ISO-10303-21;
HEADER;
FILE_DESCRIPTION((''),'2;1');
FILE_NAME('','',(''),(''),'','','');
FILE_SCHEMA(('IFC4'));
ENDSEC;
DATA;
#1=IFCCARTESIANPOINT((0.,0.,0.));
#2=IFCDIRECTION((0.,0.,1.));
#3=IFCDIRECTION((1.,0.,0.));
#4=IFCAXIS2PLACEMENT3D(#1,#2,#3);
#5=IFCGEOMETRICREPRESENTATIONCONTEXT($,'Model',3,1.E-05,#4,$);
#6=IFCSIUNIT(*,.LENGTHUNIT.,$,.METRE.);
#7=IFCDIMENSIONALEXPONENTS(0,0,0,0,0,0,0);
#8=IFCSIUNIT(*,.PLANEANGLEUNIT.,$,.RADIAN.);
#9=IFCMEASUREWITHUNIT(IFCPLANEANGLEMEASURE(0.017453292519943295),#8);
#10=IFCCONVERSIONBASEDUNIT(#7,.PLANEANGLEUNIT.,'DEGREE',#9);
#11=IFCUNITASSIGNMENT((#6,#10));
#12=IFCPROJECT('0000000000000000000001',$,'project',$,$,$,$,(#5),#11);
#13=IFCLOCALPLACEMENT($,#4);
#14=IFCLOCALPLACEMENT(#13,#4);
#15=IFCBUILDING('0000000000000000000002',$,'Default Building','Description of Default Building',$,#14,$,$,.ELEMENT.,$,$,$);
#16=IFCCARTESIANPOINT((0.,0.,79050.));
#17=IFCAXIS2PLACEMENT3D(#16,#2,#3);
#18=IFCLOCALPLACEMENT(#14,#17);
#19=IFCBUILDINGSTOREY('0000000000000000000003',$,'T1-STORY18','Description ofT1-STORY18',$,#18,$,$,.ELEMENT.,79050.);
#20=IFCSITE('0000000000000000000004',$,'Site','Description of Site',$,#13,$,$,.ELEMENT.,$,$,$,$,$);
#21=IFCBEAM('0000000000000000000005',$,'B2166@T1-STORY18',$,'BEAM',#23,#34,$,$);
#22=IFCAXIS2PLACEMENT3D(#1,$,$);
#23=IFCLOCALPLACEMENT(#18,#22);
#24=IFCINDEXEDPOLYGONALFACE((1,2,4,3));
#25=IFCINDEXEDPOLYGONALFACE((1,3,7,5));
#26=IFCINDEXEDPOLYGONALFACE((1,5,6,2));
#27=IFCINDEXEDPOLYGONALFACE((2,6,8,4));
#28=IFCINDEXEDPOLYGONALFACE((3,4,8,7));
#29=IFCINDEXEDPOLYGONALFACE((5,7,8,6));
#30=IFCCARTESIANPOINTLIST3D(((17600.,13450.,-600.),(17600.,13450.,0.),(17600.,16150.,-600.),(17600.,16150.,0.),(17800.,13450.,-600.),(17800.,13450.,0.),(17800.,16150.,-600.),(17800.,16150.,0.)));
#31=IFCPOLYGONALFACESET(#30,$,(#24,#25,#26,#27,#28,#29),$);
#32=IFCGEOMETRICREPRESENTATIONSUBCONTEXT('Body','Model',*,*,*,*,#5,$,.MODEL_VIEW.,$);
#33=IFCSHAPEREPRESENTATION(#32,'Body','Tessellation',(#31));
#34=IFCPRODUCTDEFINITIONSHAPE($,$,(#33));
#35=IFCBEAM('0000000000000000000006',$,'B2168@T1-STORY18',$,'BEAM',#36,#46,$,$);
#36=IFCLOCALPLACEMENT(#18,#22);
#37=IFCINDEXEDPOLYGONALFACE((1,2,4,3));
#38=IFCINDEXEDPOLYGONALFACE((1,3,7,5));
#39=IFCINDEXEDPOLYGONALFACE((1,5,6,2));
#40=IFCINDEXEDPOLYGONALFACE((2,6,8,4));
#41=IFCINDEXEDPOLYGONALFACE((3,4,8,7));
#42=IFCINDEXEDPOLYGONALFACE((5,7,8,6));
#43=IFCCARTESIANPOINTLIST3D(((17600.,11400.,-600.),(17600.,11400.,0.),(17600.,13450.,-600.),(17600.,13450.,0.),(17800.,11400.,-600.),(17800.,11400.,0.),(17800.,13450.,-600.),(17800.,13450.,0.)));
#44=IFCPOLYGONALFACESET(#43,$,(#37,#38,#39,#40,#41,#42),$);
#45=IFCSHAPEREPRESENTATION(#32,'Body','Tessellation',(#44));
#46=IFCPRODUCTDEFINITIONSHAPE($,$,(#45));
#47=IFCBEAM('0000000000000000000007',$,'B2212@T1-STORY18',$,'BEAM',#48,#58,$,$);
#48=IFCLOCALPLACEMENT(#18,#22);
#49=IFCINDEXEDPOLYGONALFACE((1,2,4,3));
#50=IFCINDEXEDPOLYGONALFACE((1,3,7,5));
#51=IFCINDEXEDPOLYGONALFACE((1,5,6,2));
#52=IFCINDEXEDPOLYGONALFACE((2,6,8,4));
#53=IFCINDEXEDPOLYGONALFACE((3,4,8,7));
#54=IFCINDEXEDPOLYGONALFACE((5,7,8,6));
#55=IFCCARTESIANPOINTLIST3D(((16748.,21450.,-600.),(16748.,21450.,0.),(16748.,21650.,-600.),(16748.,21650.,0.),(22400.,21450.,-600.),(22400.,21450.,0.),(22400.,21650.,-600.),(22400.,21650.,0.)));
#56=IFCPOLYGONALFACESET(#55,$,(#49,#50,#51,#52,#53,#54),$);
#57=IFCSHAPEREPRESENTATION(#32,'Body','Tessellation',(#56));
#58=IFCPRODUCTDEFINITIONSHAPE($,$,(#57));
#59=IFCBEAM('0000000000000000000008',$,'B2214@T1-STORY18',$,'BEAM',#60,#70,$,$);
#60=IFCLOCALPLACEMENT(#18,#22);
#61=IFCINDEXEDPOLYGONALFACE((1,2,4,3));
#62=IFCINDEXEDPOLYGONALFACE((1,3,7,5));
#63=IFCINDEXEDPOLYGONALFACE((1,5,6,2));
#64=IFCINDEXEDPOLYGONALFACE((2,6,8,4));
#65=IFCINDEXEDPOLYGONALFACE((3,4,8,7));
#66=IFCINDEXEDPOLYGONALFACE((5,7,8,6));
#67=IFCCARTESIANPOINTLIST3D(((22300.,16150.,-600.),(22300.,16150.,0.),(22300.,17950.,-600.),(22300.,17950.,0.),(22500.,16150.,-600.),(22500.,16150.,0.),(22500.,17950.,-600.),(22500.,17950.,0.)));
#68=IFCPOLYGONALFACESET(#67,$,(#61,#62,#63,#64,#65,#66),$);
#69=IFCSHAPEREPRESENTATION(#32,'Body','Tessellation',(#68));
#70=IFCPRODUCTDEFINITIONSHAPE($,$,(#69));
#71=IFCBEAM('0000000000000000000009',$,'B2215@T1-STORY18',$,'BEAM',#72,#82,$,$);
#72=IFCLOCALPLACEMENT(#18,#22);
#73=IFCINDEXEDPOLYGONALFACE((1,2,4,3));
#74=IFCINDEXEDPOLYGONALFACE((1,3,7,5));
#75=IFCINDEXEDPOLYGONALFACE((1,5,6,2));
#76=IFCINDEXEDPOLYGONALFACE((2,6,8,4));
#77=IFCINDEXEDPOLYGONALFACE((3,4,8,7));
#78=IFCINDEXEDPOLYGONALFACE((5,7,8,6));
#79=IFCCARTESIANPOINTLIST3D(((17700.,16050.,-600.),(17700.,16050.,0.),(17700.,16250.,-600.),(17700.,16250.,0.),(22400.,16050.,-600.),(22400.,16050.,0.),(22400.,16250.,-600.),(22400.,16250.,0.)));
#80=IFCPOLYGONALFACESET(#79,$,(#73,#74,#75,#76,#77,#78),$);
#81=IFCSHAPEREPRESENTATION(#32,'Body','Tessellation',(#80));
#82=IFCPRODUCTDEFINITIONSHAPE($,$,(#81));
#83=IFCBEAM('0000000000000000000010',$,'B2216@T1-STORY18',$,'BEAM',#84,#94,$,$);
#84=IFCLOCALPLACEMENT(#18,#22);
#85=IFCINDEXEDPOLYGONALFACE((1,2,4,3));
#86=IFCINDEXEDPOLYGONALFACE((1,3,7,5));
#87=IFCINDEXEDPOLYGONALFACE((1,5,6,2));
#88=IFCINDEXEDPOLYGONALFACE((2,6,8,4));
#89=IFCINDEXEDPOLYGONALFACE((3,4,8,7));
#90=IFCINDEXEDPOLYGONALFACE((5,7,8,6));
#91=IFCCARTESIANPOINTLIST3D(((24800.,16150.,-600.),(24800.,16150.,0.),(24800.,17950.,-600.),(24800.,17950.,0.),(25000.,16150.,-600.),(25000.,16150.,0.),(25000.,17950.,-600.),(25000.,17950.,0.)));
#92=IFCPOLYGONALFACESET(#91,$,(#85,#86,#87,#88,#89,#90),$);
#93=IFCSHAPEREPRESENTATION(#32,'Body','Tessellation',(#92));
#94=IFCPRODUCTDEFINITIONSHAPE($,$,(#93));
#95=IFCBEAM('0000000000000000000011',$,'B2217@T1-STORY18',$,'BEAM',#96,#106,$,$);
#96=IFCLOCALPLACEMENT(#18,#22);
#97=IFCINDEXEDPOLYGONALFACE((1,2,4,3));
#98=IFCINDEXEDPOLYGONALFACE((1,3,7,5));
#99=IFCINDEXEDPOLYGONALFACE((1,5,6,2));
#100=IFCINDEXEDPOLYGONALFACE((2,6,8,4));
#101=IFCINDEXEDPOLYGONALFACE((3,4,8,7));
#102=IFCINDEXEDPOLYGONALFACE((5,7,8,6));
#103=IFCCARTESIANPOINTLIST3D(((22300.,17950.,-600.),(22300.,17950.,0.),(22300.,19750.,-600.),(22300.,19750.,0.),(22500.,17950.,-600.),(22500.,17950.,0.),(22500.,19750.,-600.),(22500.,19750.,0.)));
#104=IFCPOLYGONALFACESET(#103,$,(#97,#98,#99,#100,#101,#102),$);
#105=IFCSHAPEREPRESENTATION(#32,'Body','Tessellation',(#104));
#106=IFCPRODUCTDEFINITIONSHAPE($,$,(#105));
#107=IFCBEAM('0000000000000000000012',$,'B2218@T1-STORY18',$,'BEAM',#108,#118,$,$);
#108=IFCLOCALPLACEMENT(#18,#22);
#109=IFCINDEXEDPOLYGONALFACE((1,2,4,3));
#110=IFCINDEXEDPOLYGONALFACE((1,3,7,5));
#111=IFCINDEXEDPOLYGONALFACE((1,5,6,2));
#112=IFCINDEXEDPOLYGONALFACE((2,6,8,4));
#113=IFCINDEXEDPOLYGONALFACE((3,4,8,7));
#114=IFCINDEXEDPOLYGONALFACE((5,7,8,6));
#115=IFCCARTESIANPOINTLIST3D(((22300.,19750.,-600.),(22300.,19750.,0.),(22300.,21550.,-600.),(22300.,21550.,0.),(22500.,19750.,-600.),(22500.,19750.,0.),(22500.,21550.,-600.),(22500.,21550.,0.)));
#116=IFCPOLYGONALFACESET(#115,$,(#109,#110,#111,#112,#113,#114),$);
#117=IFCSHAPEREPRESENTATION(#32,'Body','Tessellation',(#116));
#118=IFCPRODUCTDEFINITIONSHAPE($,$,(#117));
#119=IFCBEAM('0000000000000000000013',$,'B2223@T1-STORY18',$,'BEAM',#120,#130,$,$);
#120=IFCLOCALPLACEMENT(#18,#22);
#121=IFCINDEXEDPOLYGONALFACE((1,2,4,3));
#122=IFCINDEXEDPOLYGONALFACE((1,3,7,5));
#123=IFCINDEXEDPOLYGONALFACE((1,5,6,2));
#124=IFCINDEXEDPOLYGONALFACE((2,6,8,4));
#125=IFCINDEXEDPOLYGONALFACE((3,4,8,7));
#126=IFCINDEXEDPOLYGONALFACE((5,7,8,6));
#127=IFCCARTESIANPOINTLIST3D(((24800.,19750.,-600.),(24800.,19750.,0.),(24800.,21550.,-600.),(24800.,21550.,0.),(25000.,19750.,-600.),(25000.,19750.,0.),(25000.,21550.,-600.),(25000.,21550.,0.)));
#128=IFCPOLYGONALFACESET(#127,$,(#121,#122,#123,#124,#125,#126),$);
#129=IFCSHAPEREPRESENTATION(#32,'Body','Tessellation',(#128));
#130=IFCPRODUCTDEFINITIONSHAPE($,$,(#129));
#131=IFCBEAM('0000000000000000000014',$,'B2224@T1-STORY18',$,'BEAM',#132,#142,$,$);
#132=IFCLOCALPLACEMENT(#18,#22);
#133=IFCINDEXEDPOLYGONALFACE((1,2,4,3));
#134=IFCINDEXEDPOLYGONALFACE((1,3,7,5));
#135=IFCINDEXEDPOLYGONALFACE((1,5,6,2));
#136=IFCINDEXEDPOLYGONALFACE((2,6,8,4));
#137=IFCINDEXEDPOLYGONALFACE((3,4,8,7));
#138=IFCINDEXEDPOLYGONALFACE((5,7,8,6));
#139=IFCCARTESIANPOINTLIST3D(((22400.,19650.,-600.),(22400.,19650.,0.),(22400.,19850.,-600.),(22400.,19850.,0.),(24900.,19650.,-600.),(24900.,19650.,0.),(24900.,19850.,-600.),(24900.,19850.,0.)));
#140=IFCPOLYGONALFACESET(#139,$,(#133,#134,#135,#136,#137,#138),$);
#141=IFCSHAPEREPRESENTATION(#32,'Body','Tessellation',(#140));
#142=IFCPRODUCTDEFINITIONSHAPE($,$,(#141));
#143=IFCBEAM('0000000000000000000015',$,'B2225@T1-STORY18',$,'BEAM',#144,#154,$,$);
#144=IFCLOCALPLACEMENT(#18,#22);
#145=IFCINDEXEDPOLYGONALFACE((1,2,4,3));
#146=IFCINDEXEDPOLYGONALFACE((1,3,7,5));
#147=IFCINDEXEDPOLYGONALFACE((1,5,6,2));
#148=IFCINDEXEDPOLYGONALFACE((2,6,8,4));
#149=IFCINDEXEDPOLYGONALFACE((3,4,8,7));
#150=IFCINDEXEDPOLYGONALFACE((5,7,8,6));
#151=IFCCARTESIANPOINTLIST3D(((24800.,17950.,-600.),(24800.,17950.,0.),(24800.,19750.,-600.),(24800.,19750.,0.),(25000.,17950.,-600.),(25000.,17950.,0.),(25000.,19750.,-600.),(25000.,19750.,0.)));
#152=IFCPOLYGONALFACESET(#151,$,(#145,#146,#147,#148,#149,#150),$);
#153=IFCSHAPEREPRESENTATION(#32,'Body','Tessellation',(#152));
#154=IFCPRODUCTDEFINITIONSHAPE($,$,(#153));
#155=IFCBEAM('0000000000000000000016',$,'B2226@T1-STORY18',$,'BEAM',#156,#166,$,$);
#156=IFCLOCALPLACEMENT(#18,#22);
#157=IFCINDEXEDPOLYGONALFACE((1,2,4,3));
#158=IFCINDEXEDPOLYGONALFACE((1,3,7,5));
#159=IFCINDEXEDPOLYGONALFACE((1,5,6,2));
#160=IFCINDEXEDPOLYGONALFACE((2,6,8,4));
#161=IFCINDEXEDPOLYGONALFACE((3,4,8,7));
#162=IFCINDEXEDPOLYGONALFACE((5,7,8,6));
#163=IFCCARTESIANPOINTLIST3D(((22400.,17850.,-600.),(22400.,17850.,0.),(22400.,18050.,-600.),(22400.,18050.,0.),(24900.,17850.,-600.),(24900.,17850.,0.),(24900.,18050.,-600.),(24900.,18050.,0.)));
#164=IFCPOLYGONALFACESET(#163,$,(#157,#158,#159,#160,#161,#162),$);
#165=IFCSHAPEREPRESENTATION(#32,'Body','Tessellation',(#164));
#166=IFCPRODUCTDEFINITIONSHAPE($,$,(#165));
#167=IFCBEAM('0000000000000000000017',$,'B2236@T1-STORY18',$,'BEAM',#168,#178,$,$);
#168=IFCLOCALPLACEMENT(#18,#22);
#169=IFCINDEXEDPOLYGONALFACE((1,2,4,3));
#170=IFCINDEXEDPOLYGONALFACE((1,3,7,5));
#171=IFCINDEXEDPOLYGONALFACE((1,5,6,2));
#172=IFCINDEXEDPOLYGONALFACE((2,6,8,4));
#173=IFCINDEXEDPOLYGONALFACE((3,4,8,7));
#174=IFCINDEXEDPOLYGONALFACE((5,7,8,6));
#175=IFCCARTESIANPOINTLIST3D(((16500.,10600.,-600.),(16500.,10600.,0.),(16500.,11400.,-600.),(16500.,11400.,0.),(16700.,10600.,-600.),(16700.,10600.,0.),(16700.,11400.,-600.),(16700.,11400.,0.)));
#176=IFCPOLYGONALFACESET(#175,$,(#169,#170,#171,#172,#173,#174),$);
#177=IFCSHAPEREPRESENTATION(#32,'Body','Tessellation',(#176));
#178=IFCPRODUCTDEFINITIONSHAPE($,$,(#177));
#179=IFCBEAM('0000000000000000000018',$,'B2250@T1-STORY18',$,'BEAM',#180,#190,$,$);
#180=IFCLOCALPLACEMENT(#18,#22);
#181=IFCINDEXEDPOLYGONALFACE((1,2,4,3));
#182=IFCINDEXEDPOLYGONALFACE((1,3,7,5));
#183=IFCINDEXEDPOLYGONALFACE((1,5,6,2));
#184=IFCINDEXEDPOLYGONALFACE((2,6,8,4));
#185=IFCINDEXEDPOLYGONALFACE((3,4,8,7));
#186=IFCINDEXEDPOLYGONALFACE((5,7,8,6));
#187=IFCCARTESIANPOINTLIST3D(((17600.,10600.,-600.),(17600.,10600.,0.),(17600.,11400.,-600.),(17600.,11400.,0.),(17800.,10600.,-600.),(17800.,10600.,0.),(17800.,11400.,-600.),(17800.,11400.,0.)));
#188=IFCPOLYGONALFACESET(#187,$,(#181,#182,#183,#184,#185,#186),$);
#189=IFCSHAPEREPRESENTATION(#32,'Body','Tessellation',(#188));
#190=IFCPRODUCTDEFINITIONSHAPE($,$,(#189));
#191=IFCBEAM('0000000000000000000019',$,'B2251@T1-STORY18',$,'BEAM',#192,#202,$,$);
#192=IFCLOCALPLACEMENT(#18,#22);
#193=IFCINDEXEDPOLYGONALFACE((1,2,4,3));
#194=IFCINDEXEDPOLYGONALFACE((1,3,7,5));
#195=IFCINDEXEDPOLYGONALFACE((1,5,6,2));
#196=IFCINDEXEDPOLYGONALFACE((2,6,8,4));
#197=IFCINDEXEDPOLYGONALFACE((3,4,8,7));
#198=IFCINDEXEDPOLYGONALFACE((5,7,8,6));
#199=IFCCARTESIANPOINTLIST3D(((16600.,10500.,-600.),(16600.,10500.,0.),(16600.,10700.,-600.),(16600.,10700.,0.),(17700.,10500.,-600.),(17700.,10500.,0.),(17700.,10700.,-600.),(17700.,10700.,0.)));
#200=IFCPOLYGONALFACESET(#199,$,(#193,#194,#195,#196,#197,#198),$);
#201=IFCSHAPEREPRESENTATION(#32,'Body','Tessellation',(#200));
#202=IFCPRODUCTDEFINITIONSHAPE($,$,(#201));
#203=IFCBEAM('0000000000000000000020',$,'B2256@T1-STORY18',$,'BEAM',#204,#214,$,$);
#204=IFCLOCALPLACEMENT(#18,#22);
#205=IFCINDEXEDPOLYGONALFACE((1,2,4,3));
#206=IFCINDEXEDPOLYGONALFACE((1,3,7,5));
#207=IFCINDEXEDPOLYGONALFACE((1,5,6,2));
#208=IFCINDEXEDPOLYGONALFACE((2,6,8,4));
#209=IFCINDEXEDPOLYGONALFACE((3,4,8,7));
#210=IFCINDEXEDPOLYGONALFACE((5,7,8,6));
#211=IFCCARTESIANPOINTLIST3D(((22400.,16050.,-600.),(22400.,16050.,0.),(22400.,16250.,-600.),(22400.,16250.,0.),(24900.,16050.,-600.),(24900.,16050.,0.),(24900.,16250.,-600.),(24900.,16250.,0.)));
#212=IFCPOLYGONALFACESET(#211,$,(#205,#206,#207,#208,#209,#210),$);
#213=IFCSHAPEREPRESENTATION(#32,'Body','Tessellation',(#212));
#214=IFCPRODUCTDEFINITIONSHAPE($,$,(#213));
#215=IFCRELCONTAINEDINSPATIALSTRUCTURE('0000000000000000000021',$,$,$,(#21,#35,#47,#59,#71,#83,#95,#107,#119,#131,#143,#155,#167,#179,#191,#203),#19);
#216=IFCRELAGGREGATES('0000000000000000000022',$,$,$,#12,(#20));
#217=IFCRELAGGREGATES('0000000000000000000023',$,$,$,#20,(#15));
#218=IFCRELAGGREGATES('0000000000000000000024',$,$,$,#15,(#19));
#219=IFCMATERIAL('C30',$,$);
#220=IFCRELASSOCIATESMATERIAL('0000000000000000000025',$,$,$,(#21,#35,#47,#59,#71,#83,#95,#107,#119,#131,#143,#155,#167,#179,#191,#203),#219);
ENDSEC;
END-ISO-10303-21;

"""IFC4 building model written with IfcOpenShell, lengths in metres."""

from ifc_helpers import new_model, entity, si_unit, converted_unit, frame, origin_with_axes, place, context, subcontext, project, spatial, rectangle, extrude, material, element, save


model = new_model("IFC4")

# Units and contexts
model_context = context("Model", 3, precision=1e-05, world=origin_with_axes())
body_context = subcontext(model_context, "Body", "Model", "MODEL_VIEW")
ifc_project = project(units=[si_unit("LENGTHUNIT", "METRE"), converted_unit("PLANEANGLEUNIT", "DEGREE", entity("IfcPlaneAngleMeasure", 0.017453292519943295), si_unit("PLANEANGLEUNIT", "RADIAN"), dimensions=[0, 0, 0, 0, 0, 0, 0])], contexts=[model_context])

# Site, building, storey
site_placement = place(None, origin_with_axes())
site = spatial("IfcSite", under=ifc_project, at=site_placement, Name="Site", Description="Description of Site", CompositionType="ELEMENT")
building_placement = place(site_placement, origin_with_axes())
building = spatial("IfcBuilding", under=site, at=building_placement, Name="Default Building", Description="Description of Default Building", CompositionType="ELEMENT")
storey_placement = place(building_placement, frame((0.0, 0.0, 79050.0), z_axis=(0.0, 0.0, 1.0), x_axis=(1.0, 0.0, 0.0)))
storey = spatial("IfcBuildingStorey", under=building, at=storey_placement, Name="T1-STORY18", Description="Description ofT1-STORY18", CompositionType="ELEMENT", Elevation=79050.0)

# Beams
ifc_material_1 = material(Name="C30")
beam_1_placement = place(storey_placement, frame((17700.0, 13450.0, -300.0), z_axis=(0.0, 1.0, 0.0), x_axis=(-1.0, 0.0, 0.0)))
element("IfcBeam", 1, at=beam_1_placement, inside=storey, material=ifc_material_1, Name="B2166@T1-STORY18", ObjectType="BEAM", context=body_context, shape_type="SweptSolid", body=[
    extrude(rectangle(XDim=200.0, YDim=600.0), origin_with_axes(), (0.0, 0.0, 1.0), 2700.0),
])
beam_2_placement = place(storey_placement, frame((17700.0, 11400.0, -300.0), z_axis=(0.0, 1.0, 0.0), x_axis=(-1.0, 0.0, 0.0)))
element("IfcBeam", 2, at=beam_2_placement, inside=storey, material=ifc_material_1, Name="B2168@T1-STORY18", ObjectType="BEAM", context=body_context, shape_type="SweptSolid", body=[
    extrude(rectangle(XDim=200.0, YDim=600.0), origin_with_axes(), (0.0, 0.0, 1.0), 2050.0),
])
beam_3_placement = place(storey_placement, frame((16748.0, 21550.0, -300.0), z_axis=(1.0, 0.0, 0.0), x_axis=(0.0, 1.0, 0.0)))
element("IfcBeam", 3, at=beam_3_placement, inside=storey, material=ifc_material_1, Name="B2212@T1-STORY18", ObjectType="BEAM", context=body_context, shape_type="SweptSolid", body=[
    extrude(rectangle(XDim=200.0, YDim=600.0), origin_with_axes(), (0.0, 0.0, 1.0), 5652.0),
])
beam_4_placement = place(storey_placement, frame((22400.0, 16150.0, -300.0), z_axis=(0.0, 1.0, 0.0), x_axis=(-1.0, 0.0, 0.0)))
element("IfcBeam", 4, at=beam_4_placement, inside=storey, material=ifc_material_1, Name="B2214@T1-STORY18", ObjectType="BEAM", context=body_context, shape_type="SweptSolid", body=[
    extrude(rectangle(XDim=200.0, YDim=600.0), origin_with_axes(), (0.0, 0.0, 1.0), 1800.0),
])
beam_5_placement = place(storey_placement, frame((17700.0, 16150.0, -300.0), z_axis=(1.0, 0.0, 0.0), x_axis=(0.0, 1.0, 0.0)))
element("IfcBeam", 5, at=beam_5_placement, inside=storey, material=ifc_material_1, Name="B2215@T1-STORY18", ObjectType="BEAM", context=body_context, shape_type="SweptSolid", body=[
    extrude(rectangle(XDim=200.0, YDim=600.0), origin_with_axes(), (0.0, 0.0, 1.0), 4700.0),
])
for number, where, z_axis, x_axis, name in (
    (6, (24900.0, 16150.0, -300.0), (0.0, 1.0, 0.0), (-1.0, 0.0, 0.0), "B2216@T1-STORY18"),
    (7, (22400.0, 17950.0, -300.0), (0.0, 1.0, 0.0), (-1.0, 0.0, 0.0), "B2217@T1-STORY18"),
    (8, (22400.0, 19750.0, -300.0), (0.0, 1.0, 0.0), (-1.0, 0.0, 0.0), "B2218@T1-STORY18"),
    (9, (24900.0, 19750.0, -300.0), (0.0, 1.0, 0.0), (-1.0, 0.0, 0.0), "B2223@T1-STORY18"),
):
    element("IfcBeam", number, at=place(storey_placement, frame(where, z_axis=z_axis, x_axis=x_axis)), inside=storey, material=ifc_material_1, Name=name, ObjectType="BEAM", context=body_context, shape_type="SweptSolid", body=[
        extrude(rectangle(XDim=200.0, YDim=600.0), origin_with_axes(), (0.0, 0.0, 1.0), 1800.0),
    ])
beam_6_placement = place(storey_placement, frame((22400.0, 19750.0, -300.0), z_axis=(1.0, 0.0, 0.0), x_axis=(0.0, 1.0, 0.0)))
element("IfcBeam", 10, at=beam_6_placement, inside=storey, material=ifc_material_1, Name="B2224@T1-STORY18", ObjectType="BEAM", context=body_context, shape_type="SweptSolid", body=[
    extrude(rectangle(XDim=200.0, YDim=600.0), origin_with_axes(), (0.0, 0.0, 1.0), 2500.0),
])
beam_7_placement = place(storey_placement, frame((24900.0, 17950.0, -300.0), z_axis=(0.0, 1.0, 0.0), x_axis=(-1.0, 0.0, 0.0)))
element("IfcBeam", 11, at=beam_7_placement, inside=storey, material=ifc_material_1, Name="B2225@T1-STORY18", ObjectType="BEAM", context=body_context, shape_type="SweptSolid", body=[
    extrude(rectangle(XDim=200.0, YDim=600.0), origin_with_axes(), (0.0, 0.0, 1.0), 1800.0),
])
beam_8_placement = place(storey_placement, frame((22400.0, 17950.0, -300.0), z_axis=(1.0, 0.0, 0.0), x_axis=(0.0, 1.0, 0.0)))
element("IfcBeam", 12, at=beam_8_placement, inside=storey, material=ifc_material_1, Name="B2226@T1-STORY18", ObjectType="BEAM", context=body_context, shape_type="SweptSolid", body=[
    extrude(rectangle(XDim=200.0, YDim=600.0), origin_with_axes(), (0.0, 0.0, 1.0), 2500.0),
])
for number, where, z_axis, x_axis, name in (
    (13, (16600.0, 10600.0, -300.0), (0.0, 1.0, 0.0), (-1.0, 0.0, 0.0), "B2236@T1-STORY18"),
    (14, (17700.0, 10600.0, -300.0), (0.0, 1.0, 0.0), (-1.0, 0.0, 0.0), "B2250@T1-STORY18"),
):
    element("IfcBeam", number, at=place(storey_placement, frame(where, z_axis=z_axis, x_axis=x_axis)), inside=storey, material=ifc_material_1, Name=name, ObjectType="BEAM", context=body_context, shape_type="SweptSolid", body=[
        extrude(rectangle(XDim=200.0, YDim=600.0), origin_with_axes(), (0.0, 0.0, 1.0), 800.0),
    ])
beam_9_placement = place(storey_placement, frame((16600.0, 10600.0, -300.0), z_axis=(1.0, 0.0, 0.0), x_axis=(0.0, 1.0, 0.0)))
element("IfcBeam", 15, at=beam_9_placement, inside=storey, material=ifc_material_1, Name="B2251@T1-STORY18", ObjectType="BEAM", context=body_context, shape_type="SweptSolid", body=[
    extrude(rectangle(XDim=200.0, YDim=600.0), origin_with_axes(), (0.0, 0.0, 1.0), 1100.0),
])
for number, where, z_axis, x_axis, name in (
    (16, (22400.0, 16150.0, -300.0), (1.0, 0.0, 0.0), (0.0, 1.0, 0.0), "B2256@T1-STORY18"),
):
    element("IfcBeam", number, at=place(storey_placement, frame(where, z_axis=z_axis, x_axis=x_axis)), inside=storey, material=ifc_material_1, Name=name, ObjectType="BEAM", context=body_context, shape_type="SweptSolid", body=[
        extrude(rectangle(XDim=200.0, YDim=600.0), origin_with_axes(), (0.0, 0.0, 1.0), 2500.0),
    ])

save(model, "model.ifc")
